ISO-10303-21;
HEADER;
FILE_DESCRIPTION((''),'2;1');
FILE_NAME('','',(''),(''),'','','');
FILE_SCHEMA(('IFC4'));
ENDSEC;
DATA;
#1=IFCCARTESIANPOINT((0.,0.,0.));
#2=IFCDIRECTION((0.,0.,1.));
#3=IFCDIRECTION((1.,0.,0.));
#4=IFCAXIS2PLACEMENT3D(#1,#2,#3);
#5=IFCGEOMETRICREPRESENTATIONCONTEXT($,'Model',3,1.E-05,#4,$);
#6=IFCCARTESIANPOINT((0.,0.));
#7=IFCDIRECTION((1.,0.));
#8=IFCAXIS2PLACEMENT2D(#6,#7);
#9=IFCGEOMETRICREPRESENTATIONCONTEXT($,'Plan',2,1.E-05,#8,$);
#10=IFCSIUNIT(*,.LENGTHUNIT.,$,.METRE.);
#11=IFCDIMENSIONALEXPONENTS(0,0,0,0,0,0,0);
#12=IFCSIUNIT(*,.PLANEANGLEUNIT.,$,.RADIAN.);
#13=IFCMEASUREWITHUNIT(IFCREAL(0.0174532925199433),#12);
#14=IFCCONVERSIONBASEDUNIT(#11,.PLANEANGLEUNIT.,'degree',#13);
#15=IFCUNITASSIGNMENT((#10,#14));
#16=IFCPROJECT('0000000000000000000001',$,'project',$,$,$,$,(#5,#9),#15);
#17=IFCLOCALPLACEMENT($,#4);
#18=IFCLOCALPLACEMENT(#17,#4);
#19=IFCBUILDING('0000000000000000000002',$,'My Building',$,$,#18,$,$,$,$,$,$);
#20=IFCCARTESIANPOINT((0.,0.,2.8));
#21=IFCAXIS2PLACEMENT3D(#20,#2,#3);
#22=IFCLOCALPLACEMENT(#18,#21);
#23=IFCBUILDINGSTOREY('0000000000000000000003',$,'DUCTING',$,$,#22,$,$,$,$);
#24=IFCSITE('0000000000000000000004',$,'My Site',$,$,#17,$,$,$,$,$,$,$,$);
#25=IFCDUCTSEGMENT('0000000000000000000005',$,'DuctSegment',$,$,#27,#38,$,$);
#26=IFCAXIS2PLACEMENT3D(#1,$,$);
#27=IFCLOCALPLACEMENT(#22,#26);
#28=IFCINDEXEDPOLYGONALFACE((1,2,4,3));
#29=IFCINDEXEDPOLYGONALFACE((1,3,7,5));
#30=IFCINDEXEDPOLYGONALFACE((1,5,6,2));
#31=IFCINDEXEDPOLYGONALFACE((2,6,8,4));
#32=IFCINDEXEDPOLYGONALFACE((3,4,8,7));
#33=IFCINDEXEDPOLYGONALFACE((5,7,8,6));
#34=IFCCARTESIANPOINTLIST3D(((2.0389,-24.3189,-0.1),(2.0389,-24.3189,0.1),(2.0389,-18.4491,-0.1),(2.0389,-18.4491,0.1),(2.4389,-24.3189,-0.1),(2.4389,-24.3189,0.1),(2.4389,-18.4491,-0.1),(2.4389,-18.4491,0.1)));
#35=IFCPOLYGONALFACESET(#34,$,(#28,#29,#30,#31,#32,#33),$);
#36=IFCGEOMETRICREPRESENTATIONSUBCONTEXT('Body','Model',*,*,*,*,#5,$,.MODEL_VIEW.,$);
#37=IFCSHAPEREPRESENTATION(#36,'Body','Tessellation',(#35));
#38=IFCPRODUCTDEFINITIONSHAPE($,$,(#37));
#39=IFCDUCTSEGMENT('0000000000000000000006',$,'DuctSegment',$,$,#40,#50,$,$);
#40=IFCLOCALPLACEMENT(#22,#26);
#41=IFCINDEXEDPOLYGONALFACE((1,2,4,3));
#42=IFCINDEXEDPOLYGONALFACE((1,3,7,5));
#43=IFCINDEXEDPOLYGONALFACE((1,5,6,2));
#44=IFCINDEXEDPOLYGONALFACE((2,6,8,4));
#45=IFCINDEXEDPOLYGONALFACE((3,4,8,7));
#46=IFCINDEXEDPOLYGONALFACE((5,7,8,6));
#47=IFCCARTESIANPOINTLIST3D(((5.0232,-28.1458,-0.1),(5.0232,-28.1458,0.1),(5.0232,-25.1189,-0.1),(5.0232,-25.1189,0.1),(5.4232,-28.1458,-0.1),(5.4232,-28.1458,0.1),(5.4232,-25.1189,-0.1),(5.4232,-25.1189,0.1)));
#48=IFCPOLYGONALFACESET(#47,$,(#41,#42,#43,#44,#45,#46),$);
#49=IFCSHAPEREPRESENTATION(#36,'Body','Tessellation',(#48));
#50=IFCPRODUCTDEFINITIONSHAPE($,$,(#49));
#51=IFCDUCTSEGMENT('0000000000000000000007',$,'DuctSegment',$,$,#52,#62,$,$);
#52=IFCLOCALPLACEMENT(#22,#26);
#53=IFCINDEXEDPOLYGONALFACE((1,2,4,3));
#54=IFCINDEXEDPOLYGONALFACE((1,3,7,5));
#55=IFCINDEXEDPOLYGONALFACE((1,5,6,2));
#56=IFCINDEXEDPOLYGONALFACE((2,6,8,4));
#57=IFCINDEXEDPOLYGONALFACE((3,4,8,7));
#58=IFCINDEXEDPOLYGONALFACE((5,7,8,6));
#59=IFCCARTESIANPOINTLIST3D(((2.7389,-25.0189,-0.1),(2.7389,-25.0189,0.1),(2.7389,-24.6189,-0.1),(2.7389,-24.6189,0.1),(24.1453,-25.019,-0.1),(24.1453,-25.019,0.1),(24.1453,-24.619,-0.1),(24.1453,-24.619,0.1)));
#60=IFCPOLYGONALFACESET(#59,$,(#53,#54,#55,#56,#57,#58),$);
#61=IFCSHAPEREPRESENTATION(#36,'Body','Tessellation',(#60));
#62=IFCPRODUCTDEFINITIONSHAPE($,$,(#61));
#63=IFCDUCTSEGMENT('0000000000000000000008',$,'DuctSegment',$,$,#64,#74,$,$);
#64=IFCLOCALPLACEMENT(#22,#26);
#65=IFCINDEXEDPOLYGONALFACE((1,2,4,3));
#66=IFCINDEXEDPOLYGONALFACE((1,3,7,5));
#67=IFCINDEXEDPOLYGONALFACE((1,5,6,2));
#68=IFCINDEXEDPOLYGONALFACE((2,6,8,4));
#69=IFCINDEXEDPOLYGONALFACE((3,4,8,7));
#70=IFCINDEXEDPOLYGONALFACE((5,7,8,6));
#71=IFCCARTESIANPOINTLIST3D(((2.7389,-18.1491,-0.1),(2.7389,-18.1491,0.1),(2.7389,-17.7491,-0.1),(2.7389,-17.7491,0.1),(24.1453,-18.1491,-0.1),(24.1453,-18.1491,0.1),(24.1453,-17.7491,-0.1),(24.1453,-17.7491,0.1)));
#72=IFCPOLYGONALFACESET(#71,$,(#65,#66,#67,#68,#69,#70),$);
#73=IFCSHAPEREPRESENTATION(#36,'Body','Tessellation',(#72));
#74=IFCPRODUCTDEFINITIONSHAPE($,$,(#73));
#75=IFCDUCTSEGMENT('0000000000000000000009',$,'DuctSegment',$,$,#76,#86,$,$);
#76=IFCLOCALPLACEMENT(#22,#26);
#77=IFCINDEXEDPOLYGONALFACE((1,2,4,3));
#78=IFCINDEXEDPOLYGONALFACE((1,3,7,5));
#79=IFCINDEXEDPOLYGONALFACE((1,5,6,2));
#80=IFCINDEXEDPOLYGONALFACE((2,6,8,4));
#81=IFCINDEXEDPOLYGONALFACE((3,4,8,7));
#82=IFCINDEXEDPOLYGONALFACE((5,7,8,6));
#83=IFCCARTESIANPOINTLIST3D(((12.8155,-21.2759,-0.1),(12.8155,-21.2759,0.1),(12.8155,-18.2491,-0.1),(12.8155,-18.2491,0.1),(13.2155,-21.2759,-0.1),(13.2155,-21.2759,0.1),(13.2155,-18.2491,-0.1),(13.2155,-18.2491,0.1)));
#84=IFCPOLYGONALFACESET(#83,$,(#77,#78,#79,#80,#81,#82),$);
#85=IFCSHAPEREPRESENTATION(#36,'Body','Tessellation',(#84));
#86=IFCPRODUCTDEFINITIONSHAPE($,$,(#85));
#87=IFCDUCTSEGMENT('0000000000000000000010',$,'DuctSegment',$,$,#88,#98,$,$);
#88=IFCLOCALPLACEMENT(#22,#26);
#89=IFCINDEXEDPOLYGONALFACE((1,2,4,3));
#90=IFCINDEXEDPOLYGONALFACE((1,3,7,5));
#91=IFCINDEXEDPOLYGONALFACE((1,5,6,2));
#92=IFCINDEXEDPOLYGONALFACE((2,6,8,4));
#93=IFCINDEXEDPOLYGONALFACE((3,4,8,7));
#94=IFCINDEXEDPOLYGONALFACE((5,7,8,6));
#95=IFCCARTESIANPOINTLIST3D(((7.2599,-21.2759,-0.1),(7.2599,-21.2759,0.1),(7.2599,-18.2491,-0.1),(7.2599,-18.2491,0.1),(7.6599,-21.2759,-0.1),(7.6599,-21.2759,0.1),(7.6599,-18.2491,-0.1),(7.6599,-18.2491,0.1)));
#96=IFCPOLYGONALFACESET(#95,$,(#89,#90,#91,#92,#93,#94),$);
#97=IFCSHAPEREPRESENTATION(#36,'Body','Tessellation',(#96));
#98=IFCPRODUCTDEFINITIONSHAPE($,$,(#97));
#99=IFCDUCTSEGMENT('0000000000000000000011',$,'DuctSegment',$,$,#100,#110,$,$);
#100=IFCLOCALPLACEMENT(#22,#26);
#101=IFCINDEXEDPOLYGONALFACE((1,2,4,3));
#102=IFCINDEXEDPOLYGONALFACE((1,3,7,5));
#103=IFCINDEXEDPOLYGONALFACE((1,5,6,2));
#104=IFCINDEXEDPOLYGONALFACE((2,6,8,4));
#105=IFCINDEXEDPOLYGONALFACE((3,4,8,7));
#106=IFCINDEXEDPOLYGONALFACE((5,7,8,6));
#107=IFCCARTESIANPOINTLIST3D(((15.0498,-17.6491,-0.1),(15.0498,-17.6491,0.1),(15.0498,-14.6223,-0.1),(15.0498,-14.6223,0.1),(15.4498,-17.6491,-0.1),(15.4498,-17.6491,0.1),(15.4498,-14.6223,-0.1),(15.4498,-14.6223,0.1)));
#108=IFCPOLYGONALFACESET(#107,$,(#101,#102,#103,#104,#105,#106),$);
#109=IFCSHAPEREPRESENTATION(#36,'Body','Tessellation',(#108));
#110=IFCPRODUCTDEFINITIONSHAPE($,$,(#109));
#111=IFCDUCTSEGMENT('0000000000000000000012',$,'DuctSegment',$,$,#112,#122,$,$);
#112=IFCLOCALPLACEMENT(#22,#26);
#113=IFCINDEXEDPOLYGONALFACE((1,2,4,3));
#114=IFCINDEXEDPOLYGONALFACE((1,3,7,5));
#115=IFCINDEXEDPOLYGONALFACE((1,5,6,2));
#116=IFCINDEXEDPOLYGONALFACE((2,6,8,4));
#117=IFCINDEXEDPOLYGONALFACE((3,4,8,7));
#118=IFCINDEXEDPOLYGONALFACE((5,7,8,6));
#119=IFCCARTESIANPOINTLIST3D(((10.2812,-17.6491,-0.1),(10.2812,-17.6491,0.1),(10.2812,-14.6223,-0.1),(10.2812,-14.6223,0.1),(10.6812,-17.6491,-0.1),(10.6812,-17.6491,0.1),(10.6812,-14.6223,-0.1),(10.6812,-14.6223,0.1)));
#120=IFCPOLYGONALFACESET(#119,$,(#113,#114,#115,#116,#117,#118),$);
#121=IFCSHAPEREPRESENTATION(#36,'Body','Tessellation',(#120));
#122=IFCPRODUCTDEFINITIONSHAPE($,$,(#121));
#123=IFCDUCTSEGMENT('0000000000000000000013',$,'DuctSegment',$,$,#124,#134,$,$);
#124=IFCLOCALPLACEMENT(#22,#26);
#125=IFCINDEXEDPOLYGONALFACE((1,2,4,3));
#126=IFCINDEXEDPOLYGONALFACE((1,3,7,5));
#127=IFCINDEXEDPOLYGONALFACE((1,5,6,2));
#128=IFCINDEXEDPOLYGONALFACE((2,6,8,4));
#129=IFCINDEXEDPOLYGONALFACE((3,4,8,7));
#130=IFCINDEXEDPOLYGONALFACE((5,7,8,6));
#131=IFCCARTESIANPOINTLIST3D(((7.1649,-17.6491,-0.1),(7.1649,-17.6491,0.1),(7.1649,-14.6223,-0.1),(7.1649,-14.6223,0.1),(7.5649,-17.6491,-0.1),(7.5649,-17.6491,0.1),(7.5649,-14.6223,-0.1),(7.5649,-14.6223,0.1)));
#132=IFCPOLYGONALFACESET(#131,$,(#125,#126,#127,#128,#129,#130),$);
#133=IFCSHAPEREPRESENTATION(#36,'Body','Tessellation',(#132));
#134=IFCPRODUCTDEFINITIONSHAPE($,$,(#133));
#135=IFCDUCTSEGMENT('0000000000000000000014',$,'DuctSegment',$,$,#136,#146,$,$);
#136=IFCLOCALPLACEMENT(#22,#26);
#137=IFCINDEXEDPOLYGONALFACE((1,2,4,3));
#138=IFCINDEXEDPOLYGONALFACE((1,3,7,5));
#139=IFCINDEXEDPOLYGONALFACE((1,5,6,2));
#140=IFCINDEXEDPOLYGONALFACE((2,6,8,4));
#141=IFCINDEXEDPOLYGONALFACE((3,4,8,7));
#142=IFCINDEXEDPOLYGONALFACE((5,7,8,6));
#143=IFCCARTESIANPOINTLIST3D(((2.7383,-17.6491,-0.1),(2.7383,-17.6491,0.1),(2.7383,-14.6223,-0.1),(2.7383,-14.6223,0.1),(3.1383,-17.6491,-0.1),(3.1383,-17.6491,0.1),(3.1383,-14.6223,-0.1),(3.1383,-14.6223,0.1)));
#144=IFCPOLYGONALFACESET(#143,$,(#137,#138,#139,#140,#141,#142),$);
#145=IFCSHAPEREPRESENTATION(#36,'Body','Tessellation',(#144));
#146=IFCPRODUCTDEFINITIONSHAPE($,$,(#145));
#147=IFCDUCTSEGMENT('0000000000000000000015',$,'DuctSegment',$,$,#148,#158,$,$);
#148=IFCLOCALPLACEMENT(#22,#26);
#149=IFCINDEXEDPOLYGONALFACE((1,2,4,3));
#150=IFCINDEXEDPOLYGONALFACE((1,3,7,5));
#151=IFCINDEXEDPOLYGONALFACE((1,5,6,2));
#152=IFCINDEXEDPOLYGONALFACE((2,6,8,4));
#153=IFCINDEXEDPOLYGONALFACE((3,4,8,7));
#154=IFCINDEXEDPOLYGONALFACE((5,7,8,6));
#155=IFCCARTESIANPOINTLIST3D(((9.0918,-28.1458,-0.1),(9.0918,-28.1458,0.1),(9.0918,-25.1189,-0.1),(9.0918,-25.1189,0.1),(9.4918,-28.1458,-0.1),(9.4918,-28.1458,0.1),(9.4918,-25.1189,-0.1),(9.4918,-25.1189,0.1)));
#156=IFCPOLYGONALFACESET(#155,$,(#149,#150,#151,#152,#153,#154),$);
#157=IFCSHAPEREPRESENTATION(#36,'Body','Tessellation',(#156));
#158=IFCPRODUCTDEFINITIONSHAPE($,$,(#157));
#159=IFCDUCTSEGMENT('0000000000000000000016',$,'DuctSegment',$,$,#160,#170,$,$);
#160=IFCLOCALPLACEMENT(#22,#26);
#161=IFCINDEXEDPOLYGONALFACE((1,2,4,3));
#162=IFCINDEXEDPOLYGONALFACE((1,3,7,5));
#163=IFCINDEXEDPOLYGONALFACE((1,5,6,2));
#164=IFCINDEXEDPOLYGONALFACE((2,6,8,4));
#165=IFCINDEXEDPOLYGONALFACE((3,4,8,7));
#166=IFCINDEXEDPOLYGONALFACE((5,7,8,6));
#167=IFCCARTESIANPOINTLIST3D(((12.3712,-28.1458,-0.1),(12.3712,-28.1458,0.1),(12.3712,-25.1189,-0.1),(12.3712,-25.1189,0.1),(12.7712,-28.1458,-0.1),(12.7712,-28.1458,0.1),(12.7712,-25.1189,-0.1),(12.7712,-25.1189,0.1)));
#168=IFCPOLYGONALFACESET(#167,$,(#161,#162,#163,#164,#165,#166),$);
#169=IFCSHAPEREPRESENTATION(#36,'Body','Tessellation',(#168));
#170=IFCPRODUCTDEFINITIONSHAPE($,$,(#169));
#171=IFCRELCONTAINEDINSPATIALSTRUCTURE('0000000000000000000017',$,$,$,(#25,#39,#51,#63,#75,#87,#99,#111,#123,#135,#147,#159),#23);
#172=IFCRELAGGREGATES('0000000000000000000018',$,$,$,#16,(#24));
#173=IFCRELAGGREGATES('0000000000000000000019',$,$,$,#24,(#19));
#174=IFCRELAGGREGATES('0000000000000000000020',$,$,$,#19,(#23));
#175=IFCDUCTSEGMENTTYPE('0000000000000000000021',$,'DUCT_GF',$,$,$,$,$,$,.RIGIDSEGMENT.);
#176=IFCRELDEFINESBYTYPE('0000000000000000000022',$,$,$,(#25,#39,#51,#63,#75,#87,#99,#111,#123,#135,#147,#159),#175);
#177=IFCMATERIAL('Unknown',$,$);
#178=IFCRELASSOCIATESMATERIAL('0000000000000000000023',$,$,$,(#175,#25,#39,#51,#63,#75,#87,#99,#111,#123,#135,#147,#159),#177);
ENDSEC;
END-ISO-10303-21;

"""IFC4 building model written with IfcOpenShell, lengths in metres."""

from ifc_helpers import new_model, entity, si_unit, converted_unit, frame, origin_with_axes, origin_2d_with_axis, place, context, subcontext, project, spatial, rectangle, extrude, material, material_profile, profile_set, profile_usage, type_object, element, save


model = new_model("IFC4")

# Units and contexts
model_context = context("Model", 3, precision=1e-05, world=origin_with_axes())
plan_context = context("Plan", 2, precision=1e-05, world=origin_2d_with_axis())
body_context = subcontext(model_context, "Body", "Model", "MODEL_VIEW")
ifc_project = project(units=[si_unit("LENGTHUNIT", "METRE"), converted_unit("PLANEANGLEUNIT", "degree", entity("IfcReal", 0.0174532925199433), si_unit("PLANEANGLEUNIT", "RADIAN"), dimensions=[0, 0, 0, 0, 0, 0, 0])], contexts=[model_context, plan_context])

# Site, building, storey
site_placement = place(None, origin_with_axes())
site = spatial("IfcSite", under=ifc_project, at=site_placement, Name="My Site")
building_placement = place(site_placement, origin_with_axes())
building = spatial("IfcBuilding", under=site, at=building_placement, Name="My Building")
storey_placement = place(building_placement, frame((0.0, 0.0, 2.8), z_axis=(0.0, 0.0, 1.0), x_axis=(1.0, 0.0, 0.0)))
storey = spatial("IfcBuildingStorey", under=building, at=storey_placement, Name="DUCTING")

# Duct segments
ifc_material = material(Name="Unknown")
ifc_material_profile_1 = material_profile(ifc_material, rectangle(XDim=0.4, YDim=0.2))
ifc_profile_set_1 = profile_set([ifc_material_profile_1])
ifc_profile_usage_1 = profile_usage(ifc_profile_set_1, cardinal=5)
duct_segment_type = type_object("IfcDuctSegmentType", Name="DUCT_GF", PredefinedType="RIGIDSEGMENT", material=ifc_profile_set_1)
duct_segment_1_placement = place(storey_placement, frame((2.2389, -18.4491, 0.0), z_axis=(0.0, -1.0, 0.0), x_axis=(1.0, 0.0, 0.0)))
element("IfcDuctSegment", 1, at=duct_segment_1_placement, inside=storey, type_object=duct_segment_type, material=ifc_profile_usage_1, Name="DuctSegment", context=body_context, shape_type="SweptSolid", body=[
    extrude(rectangle(XDim=0.4, YDim=0.2), origin_with_axes(), (0.0, 0.0, 1.0), 5.8699),
])
ifc_profile_usage_2 = profile_usage(ifc_profile_set_1, cardinal=5)
duct_segment_2_placement = place(storey_placement, frame((5.2232, -25.1189, 0.0), z_axis=(0.0, -1.0, 0.0), x_axis=(1.0, 0.0, 0.0)))
element("IfcDuctSegment", 2, at=duct_segment_2_placement, inside=storey, type_object=duct_segment_type, material=ifc_profile_usage_2, Name="DuctSegment", context=body_context, shape_type="SweptSolid", body=[
    extrude(rectangle(XDim=0.4, YDim=0.2), origin_with_axes(), (0.0, 0.0, 1.0), 3.0268),
])
ifc_profile_usage_3 = profile_usage(ifc_profile_set_1, cardinal=5)
duct_segment_3_placement = place(storey_placement, frame((2.7389, -24.8189, 0.0), z_axis=(1.0, -0.000001, 0.000001), x_axis=(0.000001, 1.0, 0.0)))
element("IfcDuctSegment", 3, at=duct_segment_3_placement, inside=storey, type_object=duct_segment_type, material=ifc_profile_usage_3, Name="DuctSegment", context=body_context, shape_type="SweptSolid", body=[
    extrude(rectangle(XDim=0.4, YDim=0.2), origin_with_axes(), (0.0, 0.0, 1.0), 21.4064),
])
ifc_profile_usage_4 = profile_usage(ifc_profile_set_1, cardinal=5)
duct_segment_4_placement = place(storey_placement, frame((2.7389, -17.9491, 0.0), z_axis=(1.0, -0.000001, 0.000001), x_axis=(0.000001, 1.0, 0.0)))
element("IfcDuctSegment", 4, at=duct_segment_4_placement, inside=storey, type_object=duct_segment_type, material=ifc_profile_usage_4, Name="DuctSegment", context=body_context, shape_type="SweptSolid", body=[
    extrude(rectangle(XDim=0.4, YDim=0.2), origin_with_axes(), (0.0, 0.0, 1.0), 21.4064),
])
ifc_profile_usage_5 = profile_usage(ifc_profile_set_1, cardinal=5)
duct_segment_5_placement = place(storey_placement, frame((13.0155, -18.2491, 0.0), z_axis=(0.000001, -1.0, 0.0), x_axis=(1.0, 0.000001, 0.0)))
element("IfcDuctSegment", 5, at=duct_segment_5_placement, inside=storey, type_object=duct_segment_type, material=ifc_profile_usage_5, Name="DuctSegment", context=body_context, shape_type="SweptSolid", body=[
    extrude(rectangle(XDim=0.4, YDim=0.2), origin_with_axes(), (0.0, 0.0, 1.0), 3.0268),
])
ifc_profile_usage_6 = profile_usage(ifc_profile_set_1, cardinal=5)
duct_segment_6_placement = place(storey_placement, frame((7.4599, -18.2491, 0.0), z_axis=(0.000001, -1.0, 0.0), x_axis=(1.0, 0.000001, 0.0)))
element("IfcDuctSegment", 6, at=duct_segment_6_placement, inside=storey, type_object=duct_segment_type, material=ifc_profile_usage_6, Name="DuctSegment", context=body_context, shape_type="SweptSolid", body=[
    extrude(rectangle(XDim=0.4, YDim=0.2), origin_with_axes(), (0.0, 0.0, 1.0), 3.0268),
])
ifc_profile_usage_7 = profile_usage(ifc_profile_set_1, cardinal=5)
duct_segment_7_placement = place(storey_placement, frame((15.2498, -14.6223, 0.0), z_axis=(0.000001, -1.0, 0.0), x_axis=(1.0, 0.000001, 0.0)))
element("IfcDuctSegment", 7, at=duct_segment_7_placement, inside=storey, type_object=duct_segment_type, material=ifc_profile_usage_7, Name="DuctSegment", context=body_context, shape_type="SweptSolid", body=[
    extrude(rectangle(XDim=0.4, YDim=0.2), origin_with_axes(), (0.0, 0.0, 1.0), 3.0268),
])
ifc_profile_usage_8 = profile_usage(ifc_profile_set_1, cardinal=5)
duct_segment_8_placement = place(storey_placement, frame((10.4812, -14.6223, 0.0), z_axis=(0.000001, -1.0, 0.0), x_axis=(1.0, 0.000001, 0.0)))
element("IfcDuctSegment", 8, at=duct_segment_8_placement, inside=storey, type_object=duct_segment_type, material=ifc_profile_usage_8, Name="DuctSegment", context=body_context, shape_type="SweptSolid", body=[
    extrude(rectangle(XDim=0.4, YDim=0.2), origin_with_axes(), (0.0, 0.0, 1.0), 3.0268),
])
ifc_profile_usage_9 = profile_usage(ifc_profile_set_1, cardinal=5)
duct_segment_9_placement = place(storey_placement, frame((7.3649, -14.6223, 0.0), z_axis=(0.000001, -1.0, 0.0), x_axis=(1.0, 0.000001, 0.0)))
element("IfcDuctSegment", 9, at=duct_segment_9_placement, inside=storey, type_object=duct_segment_type, material=ifc_profile_usage_9, Name="DuctSegment", context=body_context, shape_type="SweptSolid", body=[
    extrude(rectangle(XDim=0.4, YDim=0.2), origin_with_axes(), (0.0, 0.0, 1.0), 3.0268),
])
ifc_profile_usage_10 = profile_usage(ifc_profile_set_1, cardinal=5)
duct_segment_10_placement = place(storey_placement, frame((2.9383, -14.6223, 0.0), z_axis=(0.000001, -1.0, 0.0), x_axis=(1.0, 0.000001, 0.0)))
element("IfcDuctSegment", 10, at=duct_segment_10_placement, inside=storey, type_object=duct_segment_type, material=ifc_profile_usage_10, Name="DuctSegment", context=body_context, shape_type="SweptSolid", body=[
    extrude(rectangle(XDim=0.4, YDim=0.2), origin_with_axes(), (0.0, 0.0, 1.0), 3.0268),
])
ifc_profile_usage_11 = profile_usage(ifc_profile_set_1, cardinal=5)
duct_segment_11_placement = place(storey_placement, frame((9.2918, -25.1189, 0.0), z_axis=(0.000001, -1.0, 0.0), x_axis=(1.0, 0.000001, 0.0)))
element("IfcDuctSegment", 11, at=duct_segment_11_placement, inside=storey, type_object=duct_segment_type, material=ifc_profile_usage_11, Name="DuctSegment", context=body_context, shape_type="SweptSolid", body=[
    extrude(rectangle(XDim=0.4, YDim=0.2), origin_with_axes(), (0.0, 0.0, 1.0), 3.0268),
])
ifc_profile_usage_12 = profile_usage(ifc_profile_set_1, cardinal=5)
duct_segment_12_placement = place(storey_placement, frame((12.5712, -25.1189, 0.0), z_axis=(0.000001, -1.0, 0.0), x_axis=(1.0, 0.000001, 0.0)))
element("IfcDuctSegment", 12, at=duct_segment_12_placement, inside=storey, type_object=duct_segment_type, material=ifc_profile_usage_12, Name="DuctSegment", context=body_context, shape_type="SweptSolid", body=[
    extrude(rectangle(XDim=0.4, YDim=0.2), origin_with_axes(), (0.0, 0.0, 1.0), 3.0268),
])

save(model, "model.ifc")
